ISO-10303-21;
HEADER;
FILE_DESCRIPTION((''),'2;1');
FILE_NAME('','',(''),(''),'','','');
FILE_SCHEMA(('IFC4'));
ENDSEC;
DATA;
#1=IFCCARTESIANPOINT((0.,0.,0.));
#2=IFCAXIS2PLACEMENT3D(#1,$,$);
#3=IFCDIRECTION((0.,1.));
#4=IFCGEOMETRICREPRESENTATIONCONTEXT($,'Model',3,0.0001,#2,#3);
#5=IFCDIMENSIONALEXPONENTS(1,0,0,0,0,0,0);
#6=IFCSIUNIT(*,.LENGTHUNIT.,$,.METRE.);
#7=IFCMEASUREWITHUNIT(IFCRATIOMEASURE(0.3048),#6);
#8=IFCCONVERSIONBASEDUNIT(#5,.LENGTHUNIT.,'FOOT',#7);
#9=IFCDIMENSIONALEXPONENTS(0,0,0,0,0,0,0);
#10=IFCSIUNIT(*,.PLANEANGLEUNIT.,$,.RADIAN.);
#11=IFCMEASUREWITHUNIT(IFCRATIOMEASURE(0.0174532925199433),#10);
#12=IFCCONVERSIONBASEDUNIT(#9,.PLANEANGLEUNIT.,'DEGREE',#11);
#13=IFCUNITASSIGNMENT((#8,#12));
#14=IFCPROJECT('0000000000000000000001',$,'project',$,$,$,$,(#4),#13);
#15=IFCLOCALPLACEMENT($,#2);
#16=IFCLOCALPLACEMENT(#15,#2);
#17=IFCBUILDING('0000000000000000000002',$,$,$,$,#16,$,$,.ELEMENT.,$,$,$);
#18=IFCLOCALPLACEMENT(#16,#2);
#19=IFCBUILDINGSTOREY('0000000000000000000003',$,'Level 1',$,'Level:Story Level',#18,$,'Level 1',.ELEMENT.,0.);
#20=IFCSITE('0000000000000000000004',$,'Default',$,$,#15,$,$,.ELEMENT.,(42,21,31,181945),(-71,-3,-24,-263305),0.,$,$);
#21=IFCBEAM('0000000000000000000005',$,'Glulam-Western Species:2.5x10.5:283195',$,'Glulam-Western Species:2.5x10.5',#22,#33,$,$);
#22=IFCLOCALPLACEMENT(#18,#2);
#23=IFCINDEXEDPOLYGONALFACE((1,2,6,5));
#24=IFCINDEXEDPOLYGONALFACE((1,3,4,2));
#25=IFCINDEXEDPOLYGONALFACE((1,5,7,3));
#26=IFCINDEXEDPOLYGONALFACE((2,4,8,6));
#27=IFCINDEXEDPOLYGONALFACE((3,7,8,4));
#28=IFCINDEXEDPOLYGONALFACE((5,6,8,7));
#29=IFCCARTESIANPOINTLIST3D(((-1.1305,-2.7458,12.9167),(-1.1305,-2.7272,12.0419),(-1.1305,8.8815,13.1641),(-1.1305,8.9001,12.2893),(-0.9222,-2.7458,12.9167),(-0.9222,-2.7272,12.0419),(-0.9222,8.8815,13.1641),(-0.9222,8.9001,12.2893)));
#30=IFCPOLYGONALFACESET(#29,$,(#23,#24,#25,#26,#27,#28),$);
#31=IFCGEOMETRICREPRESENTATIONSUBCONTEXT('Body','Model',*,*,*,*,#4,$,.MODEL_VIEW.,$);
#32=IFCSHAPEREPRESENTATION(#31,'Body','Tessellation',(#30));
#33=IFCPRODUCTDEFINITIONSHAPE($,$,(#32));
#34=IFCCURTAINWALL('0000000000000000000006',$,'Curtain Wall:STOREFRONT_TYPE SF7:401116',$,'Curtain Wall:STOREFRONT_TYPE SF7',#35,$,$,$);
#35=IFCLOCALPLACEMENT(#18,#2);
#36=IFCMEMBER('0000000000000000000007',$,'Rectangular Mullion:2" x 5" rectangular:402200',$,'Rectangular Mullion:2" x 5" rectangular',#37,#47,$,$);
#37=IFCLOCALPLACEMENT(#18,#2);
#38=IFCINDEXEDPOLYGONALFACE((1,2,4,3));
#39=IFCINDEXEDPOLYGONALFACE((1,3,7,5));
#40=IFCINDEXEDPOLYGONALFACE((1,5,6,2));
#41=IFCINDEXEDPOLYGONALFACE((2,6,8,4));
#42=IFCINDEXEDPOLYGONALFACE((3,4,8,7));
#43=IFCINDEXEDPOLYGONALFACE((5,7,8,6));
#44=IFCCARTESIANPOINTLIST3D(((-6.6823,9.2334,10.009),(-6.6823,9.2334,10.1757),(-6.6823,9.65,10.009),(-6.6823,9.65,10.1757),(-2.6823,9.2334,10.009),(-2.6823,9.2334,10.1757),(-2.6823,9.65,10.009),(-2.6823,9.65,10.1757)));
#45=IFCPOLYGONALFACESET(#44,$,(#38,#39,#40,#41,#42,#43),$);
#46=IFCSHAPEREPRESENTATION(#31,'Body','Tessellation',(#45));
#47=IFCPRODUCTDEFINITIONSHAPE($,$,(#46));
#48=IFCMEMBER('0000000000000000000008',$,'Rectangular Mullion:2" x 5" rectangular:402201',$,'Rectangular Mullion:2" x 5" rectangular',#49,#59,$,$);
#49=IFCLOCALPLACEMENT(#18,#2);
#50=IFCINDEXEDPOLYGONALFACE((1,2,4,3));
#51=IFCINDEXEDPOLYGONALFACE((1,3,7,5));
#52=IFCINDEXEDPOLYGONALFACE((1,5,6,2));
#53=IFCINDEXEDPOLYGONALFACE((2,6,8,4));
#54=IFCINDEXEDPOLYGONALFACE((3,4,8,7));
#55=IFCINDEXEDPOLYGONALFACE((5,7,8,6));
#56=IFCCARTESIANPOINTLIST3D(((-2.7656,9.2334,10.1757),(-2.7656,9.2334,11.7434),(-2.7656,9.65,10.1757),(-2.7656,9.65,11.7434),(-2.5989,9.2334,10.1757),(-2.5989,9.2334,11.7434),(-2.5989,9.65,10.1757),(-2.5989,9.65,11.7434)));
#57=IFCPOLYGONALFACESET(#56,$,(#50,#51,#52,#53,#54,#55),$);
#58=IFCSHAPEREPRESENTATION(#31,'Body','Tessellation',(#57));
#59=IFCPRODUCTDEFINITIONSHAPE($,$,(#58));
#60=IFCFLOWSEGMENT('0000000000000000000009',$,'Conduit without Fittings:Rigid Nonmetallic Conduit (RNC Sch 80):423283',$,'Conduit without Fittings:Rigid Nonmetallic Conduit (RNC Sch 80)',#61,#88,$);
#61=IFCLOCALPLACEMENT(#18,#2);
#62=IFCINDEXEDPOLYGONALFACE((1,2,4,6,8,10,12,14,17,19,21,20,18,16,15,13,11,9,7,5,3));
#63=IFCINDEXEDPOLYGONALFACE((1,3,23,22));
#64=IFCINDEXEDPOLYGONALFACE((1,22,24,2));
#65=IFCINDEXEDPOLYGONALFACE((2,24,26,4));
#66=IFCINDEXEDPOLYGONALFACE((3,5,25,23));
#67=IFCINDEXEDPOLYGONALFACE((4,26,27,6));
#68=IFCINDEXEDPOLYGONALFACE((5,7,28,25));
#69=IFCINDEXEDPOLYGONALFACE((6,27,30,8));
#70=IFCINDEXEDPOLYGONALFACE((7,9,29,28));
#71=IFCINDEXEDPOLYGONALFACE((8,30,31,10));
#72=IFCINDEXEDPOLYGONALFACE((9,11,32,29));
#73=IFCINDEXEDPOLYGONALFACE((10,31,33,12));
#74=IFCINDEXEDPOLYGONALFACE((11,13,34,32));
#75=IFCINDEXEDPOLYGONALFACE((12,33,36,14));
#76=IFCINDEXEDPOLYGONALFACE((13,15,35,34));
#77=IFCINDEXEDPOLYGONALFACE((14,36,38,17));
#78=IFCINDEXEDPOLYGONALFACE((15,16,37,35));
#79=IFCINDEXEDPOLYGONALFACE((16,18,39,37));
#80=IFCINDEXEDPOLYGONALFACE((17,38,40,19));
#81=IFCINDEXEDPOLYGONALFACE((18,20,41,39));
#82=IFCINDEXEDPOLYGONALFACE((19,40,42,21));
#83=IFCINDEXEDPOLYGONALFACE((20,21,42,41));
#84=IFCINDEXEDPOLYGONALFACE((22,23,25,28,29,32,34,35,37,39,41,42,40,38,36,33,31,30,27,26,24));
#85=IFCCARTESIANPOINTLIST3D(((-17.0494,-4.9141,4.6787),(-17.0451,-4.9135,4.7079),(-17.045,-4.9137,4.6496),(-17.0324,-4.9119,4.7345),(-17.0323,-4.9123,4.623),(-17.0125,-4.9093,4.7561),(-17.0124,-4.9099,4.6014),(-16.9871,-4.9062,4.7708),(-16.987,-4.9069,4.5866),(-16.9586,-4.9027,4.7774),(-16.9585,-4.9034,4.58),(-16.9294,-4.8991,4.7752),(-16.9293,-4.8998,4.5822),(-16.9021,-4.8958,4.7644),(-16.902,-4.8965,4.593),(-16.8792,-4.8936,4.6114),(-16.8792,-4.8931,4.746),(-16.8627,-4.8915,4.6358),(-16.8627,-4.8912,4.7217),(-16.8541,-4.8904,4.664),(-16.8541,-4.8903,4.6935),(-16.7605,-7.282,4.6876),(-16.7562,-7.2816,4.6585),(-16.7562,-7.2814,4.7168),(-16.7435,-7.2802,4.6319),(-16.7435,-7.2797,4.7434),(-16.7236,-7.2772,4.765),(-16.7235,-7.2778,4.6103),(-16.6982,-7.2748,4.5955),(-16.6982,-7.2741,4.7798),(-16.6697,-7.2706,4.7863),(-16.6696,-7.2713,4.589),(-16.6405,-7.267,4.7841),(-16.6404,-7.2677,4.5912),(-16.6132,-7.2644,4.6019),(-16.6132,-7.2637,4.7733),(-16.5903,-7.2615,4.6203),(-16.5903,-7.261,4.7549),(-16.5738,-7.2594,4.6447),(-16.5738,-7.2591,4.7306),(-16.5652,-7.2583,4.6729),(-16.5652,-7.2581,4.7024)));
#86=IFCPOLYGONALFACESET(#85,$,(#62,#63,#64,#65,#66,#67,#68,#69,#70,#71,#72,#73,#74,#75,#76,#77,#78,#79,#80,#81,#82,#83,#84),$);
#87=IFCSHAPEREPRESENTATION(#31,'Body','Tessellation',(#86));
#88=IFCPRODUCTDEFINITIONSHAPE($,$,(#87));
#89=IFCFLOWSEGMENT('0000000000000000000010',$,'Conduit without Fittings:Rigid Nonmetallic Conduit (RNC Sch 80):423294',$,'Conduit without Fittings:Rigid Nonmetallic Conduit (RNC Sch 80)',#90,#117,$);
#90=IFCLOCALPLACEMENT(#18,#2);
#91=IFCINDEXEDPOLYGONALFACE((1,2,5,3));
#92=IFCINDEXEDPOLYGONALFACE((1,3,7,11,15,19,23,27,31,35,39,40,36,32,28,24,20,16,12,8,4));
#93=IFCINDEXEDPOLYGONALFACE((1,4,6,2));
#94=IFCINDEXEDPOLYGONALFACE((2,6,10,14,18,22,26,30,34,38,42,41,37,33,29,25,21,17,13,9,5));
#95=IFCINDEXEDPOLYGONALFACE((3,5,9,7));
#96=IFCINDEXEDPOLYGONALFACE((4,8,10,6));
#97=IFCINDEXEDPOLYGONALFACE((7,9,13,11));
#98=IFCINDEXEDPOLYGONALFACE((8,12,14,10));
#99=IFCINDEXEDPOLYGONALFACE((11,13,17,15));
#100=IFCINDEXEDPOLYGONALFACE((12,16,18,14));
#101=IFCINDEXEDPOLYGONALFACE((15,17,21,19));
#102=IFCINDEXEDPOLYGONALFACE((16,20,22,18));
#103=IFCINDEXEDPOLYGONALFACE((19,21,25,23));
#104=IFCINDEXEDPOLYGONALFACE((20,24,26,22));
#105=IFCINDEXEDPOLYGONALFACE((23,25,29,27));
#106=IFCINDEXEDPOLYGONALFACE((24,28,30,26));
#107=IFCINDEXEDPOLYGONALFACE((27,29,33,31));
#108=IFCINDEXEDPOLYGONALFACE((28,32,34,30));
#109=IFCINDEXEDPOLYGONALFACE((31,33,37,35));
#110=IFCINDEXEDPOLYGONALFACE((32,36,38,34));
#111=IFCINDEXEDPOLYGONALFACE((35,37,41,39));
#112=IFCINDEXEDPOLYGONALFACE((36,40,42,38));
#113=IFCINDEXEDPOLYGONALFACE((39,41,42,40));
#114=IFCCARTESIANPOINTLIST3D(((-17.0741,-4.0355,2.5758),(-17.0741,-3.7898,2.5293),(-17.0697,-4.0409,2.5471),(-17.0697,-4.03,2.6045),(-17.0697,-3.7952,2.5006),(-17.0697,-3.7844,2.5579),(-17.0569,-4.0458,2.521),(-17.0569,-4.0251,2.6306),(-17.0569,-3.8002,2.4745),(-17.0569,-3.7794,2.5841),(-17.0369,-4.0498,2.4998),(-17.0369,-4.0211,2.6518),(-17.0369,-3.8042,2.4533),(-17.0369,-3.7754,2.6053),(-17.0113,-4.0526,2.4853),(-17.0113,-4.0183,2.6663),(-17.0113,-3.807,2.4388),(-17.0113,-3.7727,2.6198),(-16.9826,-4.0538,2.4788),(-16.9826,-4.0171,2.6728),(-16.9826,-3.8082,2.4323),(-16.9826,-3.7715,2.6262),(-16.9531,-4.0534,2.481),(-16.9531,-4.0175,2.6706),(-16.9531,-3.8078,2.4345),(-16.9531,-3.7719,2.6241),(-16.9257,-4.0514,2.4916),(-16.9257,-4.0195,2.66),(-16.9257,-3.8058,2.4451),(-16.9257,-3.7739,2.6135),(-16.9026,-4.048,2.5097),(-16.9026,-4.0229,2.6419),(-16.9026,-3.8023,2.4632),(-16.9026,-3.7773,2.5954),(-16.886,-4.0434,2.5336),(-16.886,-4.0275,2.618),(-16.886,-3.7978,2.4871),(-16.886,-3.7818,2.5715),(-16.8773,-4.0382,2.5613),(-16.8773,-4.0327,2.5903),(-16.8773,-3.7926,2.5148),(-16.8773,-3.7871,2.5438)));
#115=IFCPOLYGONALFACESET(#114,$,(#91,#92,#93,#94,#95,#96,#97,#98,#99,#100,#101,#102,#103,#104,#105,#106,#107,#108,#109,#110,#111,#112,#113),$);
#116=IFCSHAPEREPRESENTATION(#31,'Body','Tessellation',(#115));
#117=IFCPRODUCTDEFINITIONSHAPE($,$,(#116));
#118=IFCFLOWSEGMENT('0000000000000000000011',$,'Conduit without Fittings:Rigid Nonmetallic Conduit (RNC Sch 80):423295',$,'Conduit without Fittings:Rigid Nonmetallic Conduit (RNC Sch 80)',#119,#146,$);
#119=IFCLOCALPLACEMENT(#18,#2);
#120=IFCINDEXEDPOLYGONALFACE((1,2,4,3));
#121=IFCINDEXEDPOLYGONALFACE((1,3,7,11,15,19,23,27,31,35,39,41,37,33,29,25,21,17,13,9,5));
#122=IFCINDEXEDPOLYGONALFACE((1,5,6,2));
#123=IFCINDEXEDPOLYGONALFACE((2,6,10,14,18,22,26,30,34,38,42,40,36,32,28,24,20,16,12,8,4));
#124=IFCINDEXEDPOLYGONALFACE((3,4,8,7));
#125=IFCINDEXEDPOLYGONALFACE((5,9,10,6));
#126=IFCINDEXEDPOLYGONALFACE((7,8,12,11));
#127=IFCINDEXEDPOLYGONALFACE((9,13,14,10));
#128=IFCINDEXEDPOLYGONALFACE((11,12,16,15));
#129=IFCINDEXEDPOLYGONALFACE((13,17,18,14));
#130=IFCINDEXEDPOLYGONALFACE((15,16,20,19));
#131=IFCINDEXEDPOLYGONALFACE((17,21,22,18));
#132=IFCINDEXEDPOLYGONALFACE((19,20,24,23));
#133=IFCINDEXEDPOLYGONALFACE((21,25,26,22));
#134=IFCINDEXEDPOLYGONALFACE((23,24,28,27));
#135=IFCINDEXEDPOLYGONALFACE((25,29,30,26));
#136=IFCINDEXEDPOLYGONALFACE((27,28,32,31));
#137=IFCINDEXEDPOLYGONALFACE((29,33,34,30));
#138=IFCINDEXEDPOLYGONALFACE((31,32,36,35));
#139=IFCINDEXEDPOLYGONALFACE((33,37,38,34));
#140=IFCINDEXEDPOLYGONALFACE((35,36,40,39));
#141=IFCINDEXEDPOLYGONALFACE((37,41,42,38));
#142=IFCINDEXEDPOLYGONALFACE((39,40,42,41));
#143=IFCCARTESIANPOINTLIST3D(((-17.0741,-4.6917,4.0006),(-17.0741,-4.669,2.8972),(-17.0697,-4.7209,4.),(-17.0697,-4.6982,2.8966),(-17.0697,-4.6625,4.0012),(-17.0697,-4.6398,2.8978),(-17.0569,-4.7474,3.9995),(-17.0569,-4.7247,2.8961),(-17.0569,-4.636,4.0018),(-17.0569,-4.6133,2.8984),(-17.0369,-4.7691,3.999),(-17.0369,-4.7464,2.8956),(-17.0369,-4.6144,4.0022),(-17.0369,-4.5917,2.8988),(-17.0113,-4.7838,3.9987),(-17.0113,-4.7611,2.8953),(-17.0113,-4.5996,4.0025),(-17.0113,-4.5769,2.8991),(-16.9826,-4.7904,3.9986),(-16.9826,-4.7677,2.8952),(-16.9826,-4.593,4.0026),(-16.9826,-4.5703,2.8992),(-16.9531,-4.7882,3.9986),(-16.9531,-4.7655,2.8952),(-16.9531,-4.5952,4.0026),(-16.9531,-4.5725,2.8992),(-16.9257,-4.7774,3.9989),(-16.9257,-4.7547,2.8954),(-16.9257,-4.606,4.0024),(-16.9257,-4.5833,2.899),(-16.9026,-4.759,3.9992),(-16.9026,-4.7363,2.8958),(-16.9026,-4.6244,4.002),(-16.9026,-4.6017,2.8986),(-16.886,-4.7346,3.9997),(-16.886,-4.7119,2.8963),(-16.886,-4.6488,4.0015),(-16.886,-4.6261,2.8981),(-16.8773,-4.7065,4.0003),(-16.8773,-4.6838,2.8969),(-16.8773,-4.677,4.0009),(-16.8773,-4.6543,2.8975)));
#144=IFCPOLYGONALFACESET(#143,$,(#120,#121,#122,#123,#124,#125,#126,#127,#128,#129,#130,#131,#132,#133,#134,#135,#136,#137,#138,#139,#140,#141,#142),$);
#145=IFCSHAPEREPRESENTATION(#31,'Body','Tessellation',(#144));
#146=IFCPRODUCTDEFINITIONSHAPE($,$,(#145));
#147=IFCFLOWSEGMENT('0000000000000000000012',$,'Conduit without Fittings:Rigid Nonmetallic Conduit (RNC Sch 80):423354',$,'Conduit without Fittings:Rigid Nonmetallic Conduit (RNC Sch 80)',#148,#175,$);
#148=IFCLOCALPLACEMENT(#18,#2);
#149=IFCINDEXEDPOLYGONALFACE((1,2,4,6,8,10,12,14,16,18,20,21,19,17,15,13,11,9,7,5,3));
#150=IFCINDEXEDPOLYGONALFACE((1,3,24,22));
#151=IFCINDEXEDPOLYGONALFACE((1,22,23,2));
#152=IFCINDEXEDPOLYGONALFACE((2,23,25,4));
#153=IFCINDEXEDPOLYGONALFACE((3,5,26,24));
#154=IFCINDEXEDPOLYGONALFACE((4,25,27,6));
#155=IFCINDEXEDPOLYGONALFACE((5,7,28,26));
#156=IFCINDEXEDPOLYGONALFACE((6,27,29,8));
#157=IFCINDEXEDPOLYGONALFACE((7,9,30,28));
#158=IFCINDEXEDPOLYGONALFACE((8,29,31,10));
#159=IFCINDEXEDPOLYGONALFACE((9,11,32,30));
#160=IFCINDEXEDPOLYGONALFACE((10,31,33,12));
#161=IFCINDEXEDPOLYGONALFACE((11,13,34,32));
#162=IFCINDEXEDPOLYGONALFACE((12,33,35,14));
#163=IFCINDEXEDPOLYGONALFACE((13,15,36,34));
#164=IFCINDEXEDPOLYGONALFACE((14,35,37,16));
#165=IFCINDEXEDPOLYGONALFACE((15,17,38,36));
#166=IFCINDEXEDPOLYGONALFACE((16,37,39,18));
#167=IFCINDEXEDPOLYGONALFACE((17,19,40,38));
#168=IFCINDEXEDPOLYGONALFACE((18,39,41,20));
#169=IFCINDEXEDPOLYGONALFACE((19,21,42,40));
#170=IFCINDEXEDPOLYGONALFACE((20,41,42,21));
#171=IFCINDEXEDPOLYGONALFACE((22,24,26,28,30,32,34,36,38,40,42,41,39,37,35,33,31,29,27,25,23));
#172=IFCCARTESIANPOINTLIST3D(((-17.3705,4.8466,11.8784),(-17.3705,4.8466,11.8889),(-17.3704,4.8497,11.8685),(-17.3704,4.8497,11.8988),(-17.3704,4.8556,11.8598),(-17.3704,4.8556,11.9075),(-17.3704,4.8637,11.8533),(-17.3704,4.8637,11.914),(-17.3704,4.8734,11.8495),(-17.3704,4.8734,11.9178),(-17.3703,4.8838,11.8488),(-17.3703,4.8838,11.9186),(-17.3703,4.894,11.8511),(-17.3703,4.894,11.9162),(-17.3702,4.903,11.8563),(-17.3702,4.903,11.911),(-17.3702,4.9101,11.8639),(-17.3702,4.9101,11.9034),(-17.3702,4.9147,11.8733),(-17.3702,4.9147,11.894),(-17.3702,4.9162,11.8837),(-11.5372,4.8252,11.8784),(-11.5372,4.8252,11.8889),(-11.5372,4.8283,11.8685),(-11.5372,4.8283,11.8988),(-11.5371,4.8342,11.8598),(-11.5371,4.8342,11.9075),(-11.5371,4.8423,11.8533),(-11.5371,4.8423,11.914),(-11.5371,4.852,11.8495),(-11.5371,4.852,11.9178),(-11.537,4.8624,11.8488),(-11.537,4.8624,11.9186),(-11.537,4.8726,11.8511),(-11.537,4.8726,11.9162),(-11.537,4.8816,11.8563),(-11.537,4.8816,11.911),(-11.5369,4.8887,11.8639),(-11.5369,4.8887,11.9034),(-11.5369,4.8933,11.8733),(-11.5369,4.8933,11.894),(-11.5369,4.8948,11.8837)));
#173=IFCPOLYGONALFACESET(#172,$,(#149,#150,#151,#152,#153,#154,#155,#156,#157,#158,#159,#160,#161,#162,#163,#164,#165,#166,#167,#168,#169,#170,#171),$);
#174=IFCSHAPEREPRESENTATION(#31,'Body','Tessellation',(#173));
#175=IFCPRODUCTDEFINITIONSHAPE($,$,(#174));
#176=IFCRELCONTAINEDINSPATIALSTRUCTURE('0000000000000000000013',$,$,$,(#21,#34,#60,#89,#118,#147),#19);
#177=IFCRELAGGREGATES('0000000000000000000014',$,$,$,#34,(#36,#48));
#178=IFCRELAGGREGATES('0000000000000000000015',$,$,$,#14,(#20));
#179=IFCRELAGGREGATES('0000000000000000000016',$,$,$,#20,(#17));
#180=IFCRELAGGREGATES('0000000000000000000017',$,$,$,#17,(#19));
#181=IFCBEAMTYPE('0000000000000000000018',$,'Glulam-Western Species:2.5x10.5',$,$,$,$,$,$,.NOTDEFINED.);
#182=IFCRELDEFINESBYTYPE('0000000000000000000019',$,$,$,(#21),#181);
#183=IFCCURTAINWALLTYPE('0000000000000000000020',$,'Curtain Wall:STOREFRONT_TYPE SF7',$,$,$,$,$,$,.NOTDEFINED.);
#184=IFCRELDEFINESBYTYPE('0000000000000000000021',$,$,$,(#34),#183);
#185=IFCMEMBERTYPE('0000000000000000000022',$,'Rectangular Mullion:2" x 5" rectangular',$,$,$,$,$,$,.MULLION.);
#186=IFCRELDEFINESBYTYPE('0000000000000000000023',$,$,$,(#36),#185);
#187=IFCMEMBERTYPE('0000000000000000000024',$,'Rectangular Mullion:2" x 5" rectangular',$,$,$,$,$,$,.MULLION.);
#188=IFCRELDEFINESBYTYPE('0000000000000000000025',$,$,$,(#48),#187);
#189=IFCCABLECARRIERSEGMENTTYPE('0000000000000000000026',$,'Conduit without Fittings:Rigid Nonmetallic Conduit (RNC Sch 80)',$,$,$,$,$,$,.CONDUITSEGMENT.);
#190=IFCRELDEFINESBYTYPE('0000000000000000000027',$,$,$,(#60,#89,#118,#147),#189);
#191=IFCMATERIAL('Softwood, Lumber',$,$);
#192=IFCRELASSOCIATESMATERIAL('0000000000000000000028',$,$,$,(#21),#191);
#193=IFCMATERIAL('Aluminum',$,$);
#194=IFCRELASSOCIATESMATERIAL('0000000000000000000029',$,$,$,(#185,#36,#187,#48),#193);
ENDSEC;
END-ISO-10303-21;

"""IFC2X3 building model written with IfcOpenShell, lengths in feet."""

from ifc_helpers import new_model, entity, si_unit, converted_unit, direction, frame, frame_2d, origin, origin_2d_with_axis, place, context, subcontext, project, spatial, rectangle, circle, extrude, source, transform, mapped, material, type_object, type_shapes, element, aggregate, save


model = new_model("IFC2X3")

# Units and contexts
model_context = context("Model", 3, precision=0.0001, world=origin(), true_north=direction((0.0, 1.0)))
body_context = subcontext(model_context, "Body", "Model", "MODEL_VIEW")
ifc_project = project(units=[converted_unit("LENGTHUNIT", "FOOT", entity("IfcRatioMeasure", 0.3048), si_unit("LENGTHUNIT", "METRE"), dimensions=[1, 0, 0, 0, 0, 0, 0]), converted_unit("PLANEANGLEUNIT", "DEGREE", entity("IfcRatioMeasure", 0.0174532925199433), si_unit("PLANEANGLEUNIT", "RADIAN"), dimensions=[0, 0, 0, 0, 0, 0, 0])], contexts=[model_context])

# Site, building, storey
site_placement = place(None, origin())
site = spatial("IfcSite", under=ifc_project, at=site_placement, Name="Default", CompositionType="ELEMENT", RefLatitude=(42, 21, 31, 181945), RefLongitude=(-71, -3, -24, -263305), RefElevation=0.0)
building_placement = place(site_placement, origin())
building = spatial("IfcBuilding", under=site, at=building_placement, CompositionType="ELEMENT")
storey_placement = place(building_placement, origin())
storey = spatial("IfcBuildingStorey", under=building, at=storey_placement, Name="Level 1", ObjectType="Level:Story Level", LongName="Level 1", CompositionType="ELEMENT", Elevation=0.0)

# Beam
ifc_material_1 = material(Name="Softwood, Lumber")
beam_type = type_object("IfcBeamType", Name="Glulam-Western Species:2.5x10.5", PredefinedType="NOTDEFINED")
beam_placement = place(storey_placement, frame((-1.0263, 9.0042, 13.1667), z_axis=(0.0, -0.021272, 0.999774), x_axis=(0.0, -0.999774, -0.021272)))
element("IfcBeam", 1, at=beam_placement, inside=storey, type_object=beam_type, material=ifc_material_1, Name="Glulam-Western Species:2.5x10.5:283195", ObjectType="Glulam-Western Species:2.5x10.5", context=body_context, shape_type="SweptSolid", body=[
    extrude(rectangle(XDim=0.875, YDim=0.2083, at=origin_2d_with_axis()), frame((0.1228, 0.0, -0.4375), z_axis=(1.0, 0.0, 0.0), x_axis=(0.0, 0.0, -1.0)), (0.0, 0.0, 1.0), 11.6299),
])

# Curtain wall, members
curtain_wall_type = type_object("IfcCurtainWallType", Name="Curtain Wall:STOREFRONT_TYPE SF7", PredefinedType="NOTDEFINED")
curtain_wall_placement = place(storey_placement, origin())
curtain_wall = element("IfcCurtainWall", 2, at=curtain_wall_placement, inside=storey, type_object=curtain_wall_type, Name="Curtain Wall:STOREFRONT_TYPE SF7:401116", ObjectType="Curtain Wall:STOREFRONT_TYPE SF7")
ifc_material_2 = material(Name="Aluminum")
member_type_1 = type_object("IfcMemberType", Name="Rectangular Mullion:2\" x 5\" rectangular", PredefinedType="MULLION", material=ifc_material_2)
shared_shape_1 = source(origin(), body_context, "Body", "SweptSolid", [
    extrude(rectangle(XDim=0.4167, YDim=0.1667, at=origin_2d_with_axis()), frame((-0.0833, 0.0, -4.0), z_axis=(0.0, 0.0, 1.0), x_axis=(0.0, -1.0, 0.0)), (0.0, 0.0, 1.0), 4.0),
])
type_shapes(member_type_1, [shared_shape_1])
member_1_placement = place(curtain_wall_placement, frame((-2.6823, 9.4417, 10.009), z_axis=(1.0, 0.0, 0.0), x_axis=(0.0, 0.0, -1.0)))
member_1 = element("IfcMember", 3, at=member_1_placement, type_object=member_type_1, material=ifc_material_2, Name="Rectangular Mullion:2\" x 5\" rectangular:402200", ObjectType="Rectangular Mullion:2\" x 5\" rectangular", context=body_context, shape_type="MappedRepresentation", body=[
    mapped(shared_shape_1, transform((0.0, 0.0, 0.0), scale=1.0)),
])
member_type_2 = type_object("IfcMemberType", Name="Rectangular Mullion:2\" x 5\" rectangular", PredefinedType="MULLION", material=ifc_material_2)
shared_shape_2 = source(origin(), body_context, "Body", "SweptSolid", [
    extrude(rectangle(XDim=0.4167, YDim=0.1667, at=origin_2d_with_axis()), frame((0.0, 0.0, -1.5677), z_axis=(0.0, 0.0, 1.0), x_axis=(0.0, -1.0, 0.0)), (0.0, 0.0, 1.0), 1.5677),
])
type_shapes(member_type_2, [shared_shape_2])
member_2_placement = place(curtain_wall_placement, frame((-2.6823, 9.4417, 10.1757), z_axis=(0.0, 0.0, -1.0), x_axis=(-1.0, 0.0, 0.0)))
member_2 = element("IfcMember", 4, at=member_2_placement, type_object=member_type_2, material=ifc_material_2, Name="Rectangular Mullion:2\" x 5\" rectangular:402201", ObjectType="Rectangular Mullion:2\" x 5\" rectangular", context=body_context, shape_type="MappedRepresentation", body=[
    mapped(shared_shape_2, transform((0.0, 0.0, 0.0), scale=1.0)),
])
aggregate(curtain_wall, [member_1, member_2])

# Flow segments
cable_carrier_segment_type = type_object("IfcCableCarrierSegmentType", Name="Conduit without Fittings:Rigid Nonmetallic Conduit (RNC Sch 80)", PredefinedType="CONDUITSEGMENT")
flow_segment_1_placement = place(storey_placement, origin())
element("IfcFlowSegment", 5, at=flow_segment_1_placement, inside=storey, type_object=cable_carrier_segment_type, Name="Conduit without Fittings:Rigid Nonmetallic Conduit (RNC Sch 80):423283", ObjectType="Conduit without Fittings:Rigid Nonmetallic Conduit (RNC Sch 80)", context=body_context, shape_type="SweptSolid", body=[
    extrude(circle(Radius=0.099, at=frame_2d((0.0, 0.0), x_axis=(1.0, 0.0))), frame((-16.6623, -7.2701, 4.6876), z_axis=(-0.1211, 0.992633, -0.003738), x_axis=(-0.99264, -0.121101, 0.0)), (0.0, 0.0, 1.0), 2.3855),
])
flow_segment_2_placement = place(storey_placement, origin())
element("IfcFlowSegment", 6, at=flow_segment_2_placement, inside=storey, type_object=cable_carrier_segment_type, Name="Conduit without Fittings:Rigid Nonmetallic Conduit (RNC Sch 80):423294", ObjectType="Conduit without Fittings:Rigid Nonmetallic Conduit (RNC Sch 80)", context=body_context, shape_type="SweptSolid", body=[
    extrude(circle(Radius=0.099, at=frame_2d((0.0, 0.0), x_axis=(1.0, 0.0))), frame((-16.9752, -4.0355, 2.5758), z_axis=(0.0, 0.982539, -0.186057), x_axis=(-1.0, 0.0, 0.0)), (0.0, 0.0, 1.0), 0.25),
])
flow_segment_3_placement = place(storey_placement, origin())
element("IfcFlowSegment", 7, at=flow_segment_3_placement, inside=storey, type_object=cable_carrier_segment_type, Name="Conduit without Fittings:Rigid Nonmetallic Conduit (RNC Sch 80):423295", ObjectType="Conduit without Fittings:Rigid Nonmetallic Conduit (RNC Sch 80)", context=body_context, shape_type="SweptSolid", body=[
    extrude(circle(Radius=0.099, at=frame_2d((0.0, 0.0), x_axis=(1.0, 0.0))), frame((-16.9752, -4.6917, 4.0006), z_axis=(0.0, 0.020568, -0.999788), x_axis=(-1.0, 0.0, 0.0)), (0.0, 0.0, 1.0), 1.1036),
])
flow_segment_4_placement = place(storey_placement, origin())
element("IfcFlowSegment", 8, at=flow_segment_4_placement, inside=storey, type_object=cable_carrier_segment_type, Name="Conduit without Fittings:Rigid Nonmetallic Conduit (RNC Sch 80):423354", ObjectType="Conduit without Fittings:Rigid Nonmetallic Conduit (RNC Sch 80)", context=body_context, shape_type="SweptSolid", body=[
    extrude(circle(Radius=0.035, at=origin_2d_with_axis()), frame((-17.3703, 4.8812, 11.8837), z_axis=(0.999993, -0.003666, 0.0), x_axis=(0.003666, 0.999993, 0.0)), (0.0, 0.0, 1.0), 5.8333),
])

save(model, "model.ifc")
